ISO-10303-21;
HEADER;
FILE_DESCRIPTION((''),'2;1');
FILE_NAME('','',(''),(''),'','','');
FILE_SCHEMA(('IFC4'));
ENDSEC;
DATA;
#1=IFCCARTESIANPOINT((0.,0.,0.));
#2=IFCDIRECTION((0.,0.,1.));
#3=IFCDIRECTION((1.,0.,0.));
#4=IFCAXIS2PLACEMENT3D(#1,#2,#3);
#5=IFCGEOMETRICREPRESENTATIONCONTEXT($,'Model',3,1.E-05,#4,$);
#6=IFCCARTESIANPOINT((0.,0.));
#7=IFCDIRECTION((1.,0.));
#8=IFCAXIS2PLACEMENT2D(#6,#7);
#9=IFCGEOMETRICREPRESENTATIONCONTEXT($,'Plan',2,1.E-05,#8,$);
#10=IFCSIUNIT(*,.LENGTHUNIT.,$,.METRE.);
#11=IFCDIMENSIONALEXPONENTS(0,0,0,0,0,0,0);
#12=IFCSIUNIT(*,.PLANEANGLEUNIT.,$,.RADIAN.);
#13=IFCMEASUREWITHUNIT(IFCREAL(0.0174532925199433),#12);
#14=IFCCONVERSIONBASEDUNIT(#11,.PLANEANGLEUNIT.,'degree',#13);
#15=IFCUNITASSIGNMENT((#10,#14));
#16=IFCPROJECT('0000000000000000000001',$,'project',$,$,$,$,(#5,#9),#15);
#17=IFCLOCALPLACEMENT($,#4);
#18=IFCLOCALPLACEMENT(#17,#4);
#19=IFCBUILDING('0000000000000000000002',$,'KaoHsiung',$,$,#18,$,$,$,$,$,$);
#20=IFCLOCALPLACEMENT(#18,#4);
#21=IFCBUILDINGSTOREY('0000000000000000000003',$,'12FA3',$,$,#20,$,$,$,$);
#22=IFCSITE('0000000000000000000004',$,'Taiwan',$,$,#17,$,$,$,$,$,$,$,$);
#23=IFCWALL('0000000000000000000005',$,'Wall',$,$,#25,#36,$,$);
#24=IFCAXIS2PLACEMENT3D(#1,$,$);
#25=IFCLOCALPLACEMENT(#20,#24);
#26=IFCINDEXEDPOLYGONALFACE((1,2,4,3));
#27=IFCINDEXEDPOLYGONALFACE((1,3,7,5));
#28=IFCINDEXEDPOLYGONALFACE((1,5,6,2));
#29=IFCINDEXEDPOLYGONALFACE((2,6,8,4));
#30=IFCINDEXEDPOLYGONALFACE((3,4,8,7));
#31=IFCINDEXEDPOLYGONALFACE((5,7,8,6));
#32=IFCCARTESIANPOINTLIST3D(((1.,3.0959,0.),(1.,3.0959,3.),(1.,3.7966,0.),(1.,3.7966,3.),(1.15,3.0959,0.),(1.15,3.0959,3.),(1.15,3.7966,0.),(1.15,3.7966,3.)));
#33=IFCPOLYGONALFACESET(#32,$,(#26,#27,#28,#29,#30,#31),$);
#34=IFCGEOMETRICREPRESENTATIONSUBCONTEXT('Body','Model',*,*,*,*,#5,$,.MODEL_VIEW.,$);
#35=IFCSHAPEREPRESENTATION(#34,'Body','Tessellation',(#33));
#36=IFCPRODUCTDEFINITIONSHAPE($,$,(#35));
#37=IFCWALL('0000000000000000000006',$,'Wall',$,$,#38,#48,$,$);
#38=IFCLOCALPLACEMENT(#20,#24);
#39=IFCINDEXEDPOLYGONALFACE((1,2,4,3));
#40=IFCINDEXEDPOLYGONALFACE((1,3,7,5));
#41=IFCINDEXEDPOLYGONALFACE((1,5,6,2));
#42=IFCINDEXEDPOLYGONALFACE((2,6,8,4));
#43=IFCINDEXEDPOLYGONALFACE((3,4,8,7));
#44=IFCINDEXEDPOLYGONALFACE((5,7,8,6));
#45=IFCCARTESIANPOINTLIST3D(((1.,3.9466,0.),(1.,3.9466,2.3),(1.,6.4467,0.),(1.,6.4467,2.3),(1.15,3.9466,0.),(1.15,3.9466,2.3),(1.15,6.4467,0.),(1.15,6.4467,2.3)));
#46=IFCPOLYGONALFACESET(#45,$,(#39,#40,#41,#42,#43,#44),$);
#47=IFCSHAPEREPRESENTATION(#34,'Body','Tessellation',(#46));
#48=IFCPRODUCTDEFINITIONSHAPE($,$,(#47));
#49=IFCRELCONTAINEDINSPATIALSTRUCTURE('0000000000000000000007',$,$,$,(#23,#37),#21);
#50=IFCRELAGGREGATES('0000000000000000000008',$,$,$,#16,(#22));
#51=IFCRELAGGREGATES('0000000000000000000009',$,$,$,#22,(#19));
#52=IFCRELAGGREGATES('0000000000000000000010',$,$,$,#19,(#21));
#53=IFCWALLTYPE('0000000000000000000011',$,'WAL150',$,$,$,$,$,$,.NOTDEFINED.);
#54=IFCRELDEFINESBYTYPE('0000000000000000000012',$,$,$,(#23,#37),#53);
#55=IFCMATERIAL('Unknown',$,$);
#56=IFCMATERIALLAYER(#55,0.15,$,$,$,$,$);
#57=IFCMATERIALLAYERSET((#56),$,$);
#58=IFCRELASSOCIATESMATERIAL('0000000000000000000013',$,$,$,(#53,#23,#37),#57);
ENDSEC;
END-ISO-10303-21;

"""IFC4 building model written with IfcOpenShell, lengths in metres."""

from ifc_helpers import new_model, entity, si_unit, converted_unit, frame, origin_with_axes, origin_2d_with_axis, place, context, subcontext, project, spatial, line, indexed_curve, outline, extrude, material, layer, layer_set, layer_usage, type_object, element, save


model = new_model("IFC4")

# Units and contexts
model_context = context("Model", 3, precision=1e-05, world=origin_with_axes())
plan_context = context("Plan", 2, precision=1e-05, world=origin_2d_with_axis())
body_context = subcontext(model_context, "Body", "Model", "MODEL_VIEW")
ifc_project = project(units=[si_unit("LENGTHUNIT", "METRE"), converted_unit("PLANEANGLEUNIT", "degree", entity("IfcReal", 0.0174532925199433), si_unit("PLANEANGLEUNIT", "RADIAN"), dimensions=[0, 0, 0, 0, 0, 0, 0])], contexts=[model_context, plan_context])

# Site, building, storey
site_placement = place(None, origin_with_axes())
site = spatial("IfcSite", under=ifc_project, at=site_placement, Name="Taiwan")
building_placement = place(site_placement, origin_with_axes())
building = spatial("IfcBuilding", under=site, at=building_placement, Name="KaoHsiung")
storey_placement = place(building_placement, origin_with_axes())
storey = spatial("IfcBuildingStorey", under=building, at=storey_placement, Name="12FA3")

# Shared definitions
ifc_material = material(Name="Unknown")

# Walls
ifc_layer_1 = layer(ifc_material, 0.15)
ifc_layer_set_1 = layer_set([ifc_layer_1])
wall_type_1 = type_object("IfcWallType", Name="WAL150", PredefinedType="NOTDEFINED", material=ifc_layer_set_1)
ifc_layer_usage_1 = layer_usage(ifc_layer_set_1, "AXIS2", "POSITIVE", 0.0)
wall_1_placement = place(storey_placement, frame((1.0, 3.7966, 0.0), z_axis=(0.0, 0.0, 1.0), x_axis=(0.0, -1.0, 0.0)))
element("IfcWall", 1, at=wall_1_placement, inside=storey, type_object=wall_type_1, material=ifc_layer_usage_1, Name="Wall", context=body_context, shape_type="SweptSolid", body=[
    extrude(outline(indexed_curve([(0.0, 0.0), (0.0, 0.15), (0.7007, 0.15), (0.7007, 0.0)], segments=[line(1, 2, 3, 4, 1)])), origin_with_axes(), (0.0, 0.0, 1.0), 3.0),
])
ifc_layer_usage_2 = layer_usage(ifc_layer_set_1, "AXIS2", "POSITIVE", 0.0)
wall_2_placement = place(storey_placement, frame((1.0, 6.4467, 0.0), z_axis=(0.0, 0.0, 1.0), x_axis=(0.0, -1.0, 0.0)))
element("IfcWall", 2, at=wall_2_placement, inside=storey, type_object=wall_type_1, material=ifc_layer_usage_2, Name="Wall", context=body_context, shape_type="SweptSolid", body=[
    extrude(outline(indexed_curve([(0.0, 0.0), (0.0, 0.15), (2.5001, 0.15), (2.5001, 0.0)], segments=[line(1, 2, 3, 4, 1)])), origin_with_axes(), (0.0, 0.0, 1.0), 2.3),
])

save(model, "model.ifc")
